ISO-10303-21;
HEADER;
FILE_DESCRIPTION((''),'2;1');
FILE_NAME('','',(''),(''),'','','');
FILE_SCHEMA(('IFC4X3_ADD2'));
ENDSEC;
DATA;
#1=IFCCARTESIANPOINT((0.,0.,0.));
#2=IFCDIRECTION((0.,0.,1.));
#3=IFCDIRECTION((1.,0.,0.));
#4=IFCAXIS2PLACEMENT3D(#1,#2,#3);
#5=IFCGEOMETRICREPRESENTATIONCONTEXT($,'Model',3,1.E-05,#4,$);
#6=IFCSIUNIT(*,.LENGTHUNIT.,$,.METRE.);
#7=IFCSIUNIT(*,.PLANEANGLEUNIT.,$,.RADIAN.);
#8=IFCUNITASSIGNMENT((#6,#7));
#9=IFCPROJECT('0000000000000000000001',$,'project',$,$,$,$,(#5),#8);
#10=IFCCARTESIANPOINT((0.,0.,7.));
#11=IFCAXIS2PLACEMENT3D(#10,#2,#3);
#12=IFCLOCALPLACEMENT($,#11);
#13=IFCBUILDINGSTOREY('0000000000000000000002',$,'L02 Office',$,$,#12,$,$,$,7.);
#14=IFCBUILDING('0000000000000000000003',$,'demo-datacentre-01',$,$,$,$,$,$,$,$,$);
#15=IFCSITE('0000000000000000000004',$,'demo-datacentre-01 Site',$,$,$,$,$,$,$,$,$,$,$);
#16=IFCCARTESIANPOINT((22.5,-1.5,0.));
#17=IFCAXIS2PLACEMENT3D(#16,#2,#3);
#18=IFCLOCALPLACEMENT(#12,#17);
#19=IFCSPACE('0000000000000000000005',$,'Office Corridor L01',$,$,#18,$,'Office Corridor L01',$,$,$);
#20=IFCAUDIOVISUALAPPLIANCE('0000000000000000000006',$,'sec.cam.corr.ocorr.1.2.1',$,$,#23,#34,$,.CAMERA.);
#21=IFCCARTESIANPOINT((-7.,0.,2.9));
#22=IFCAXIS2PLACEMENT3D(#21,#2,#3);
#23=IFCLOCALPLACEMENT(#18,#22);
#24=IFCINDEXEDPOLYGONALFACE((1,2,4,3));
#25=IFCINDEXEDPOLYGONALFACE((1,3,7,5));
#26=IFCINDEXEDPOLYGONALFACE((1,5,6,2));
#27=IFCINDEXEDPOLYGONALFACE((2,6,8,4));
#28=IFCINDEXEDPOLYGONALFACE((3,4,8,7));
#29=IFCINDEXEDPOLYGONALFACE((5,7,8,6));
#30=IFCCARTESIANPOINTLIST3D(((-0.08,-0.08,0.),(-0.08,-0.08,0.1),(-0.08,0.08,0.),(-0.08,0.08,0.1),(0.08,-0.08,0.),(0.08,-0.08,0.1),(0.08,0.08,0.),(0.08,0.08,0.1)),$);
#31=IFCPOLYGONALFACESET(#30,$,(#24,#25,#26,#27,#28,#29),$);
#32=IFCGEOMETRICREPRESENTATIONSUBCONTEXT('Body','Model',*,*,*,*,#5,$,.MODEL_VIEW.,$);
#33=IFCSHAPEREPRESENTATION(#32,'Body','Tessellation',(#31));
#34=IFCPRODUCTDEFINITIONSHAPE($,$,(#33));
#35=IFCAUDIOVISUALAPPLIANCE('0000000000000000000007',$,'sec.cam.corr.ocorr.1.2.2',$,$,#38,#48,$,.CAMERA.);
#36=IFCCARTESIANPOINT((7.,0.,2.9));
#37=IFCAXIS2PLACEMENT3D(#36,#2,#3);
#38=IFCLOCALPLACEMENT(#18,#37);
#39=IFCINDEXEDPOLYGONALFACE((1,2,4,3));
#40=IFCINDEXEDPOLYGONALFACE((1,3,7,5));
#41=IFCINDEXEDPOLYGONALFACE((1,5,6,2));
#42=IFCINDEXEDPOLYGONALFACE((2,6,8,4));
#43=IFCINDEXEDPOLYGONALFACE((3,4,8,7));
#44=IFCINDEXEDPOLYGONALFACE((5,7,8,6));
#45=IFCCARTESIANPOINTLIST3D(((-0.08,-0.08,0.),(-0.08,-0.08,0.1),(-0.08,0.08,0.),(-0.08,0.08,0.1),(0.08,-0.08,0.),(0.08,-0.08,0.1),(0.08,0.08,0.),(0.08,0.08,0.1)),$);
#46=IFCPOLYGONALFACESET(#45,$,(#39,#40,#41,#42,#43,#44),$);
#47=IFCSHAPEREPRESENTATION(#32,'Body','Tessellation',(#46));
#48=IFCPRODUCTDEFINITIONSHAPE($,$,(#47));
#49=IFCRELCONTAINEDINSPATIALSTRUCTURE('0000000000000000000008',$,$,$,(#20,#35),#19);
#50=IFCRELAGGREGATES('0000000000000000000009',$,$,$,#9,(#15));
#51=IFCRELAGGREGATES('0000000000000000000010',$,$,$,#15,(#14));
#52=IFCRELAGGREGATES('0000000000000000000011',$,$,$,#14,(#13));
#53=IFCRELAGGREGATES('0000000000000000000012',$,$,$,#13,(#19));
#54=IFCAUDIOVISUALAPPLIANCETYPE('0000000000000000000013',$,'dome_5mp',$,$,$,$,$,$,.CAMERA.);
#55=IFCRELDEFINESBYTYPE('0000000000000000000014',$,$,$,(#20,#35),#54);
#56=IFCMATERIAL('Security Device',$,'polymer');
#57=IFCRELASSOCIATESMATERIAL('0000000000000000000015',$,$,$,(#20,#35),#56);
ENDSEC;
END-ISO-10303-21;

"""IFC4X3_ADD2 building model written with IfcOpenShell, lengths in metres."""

from ifc_helpers import new_model, si_unit, frame, origin_with_axes, place, context, subcontext, project, spatial, rectangle, extrude, source, transform, mapped, material, type_object, type_shapes, element, save


model = new_model("IFC4X3_ADD2")

# Units and contexts
model_context = context("Model", 3, precision=1e-05, world=origin_with_axes())
body_context = subcontext(model_context, "Body", "Model", "MODEL_VIEW")
ifc_project = project(units=[si_unit("LENGTHUNIT", "METRE"), si_unit("PLANEANGLEUNIT", "RADIAN")], contexts=[model_context])

# Site, building, storey, space
site = spatial("IfcSite", under=ifc_project, Name="demo-datacentre-01 Site")
building = spatial("IfcBuilding", under=site, Name="demo-datacentre-01")
storey_placement = place(None, frame((0.0, 0.0, 7.0), z_axis=(0.0, 0.0, 1.0), x_axis=(1.0, 0.0, 0.0)))
storey = spatial("IfcBuildingStorey", under=building, at=storey_placement, Name="L02 Office", Elevation=7.0)
space_placement = place(storey_placement, frame((22.5, -1.5, 0.0), z_axis=(0.0, 0.0, 1.0), x_axis=(1.0, 0.0, 0.0)))
space = spatial("IfcSpace", under=storey, at=space_placement, Name="Office Corridor L01", LongName="Office Corridor L01")

# Audio visual appliances
ifc_material = material(Name="Security Device", Category="polymer")
audio_visual_appliance_type = type_object("IfcAudioVisualApplianceType", Name="dome_5mp", PredefinedType="CAMERA")
shared_shape = source(origin_with_axes(), body_context, "Body", "SweptSolid", [
    extrude(rectangle(XDim=0.16, YDim=0.16), origin_with_axes(), (0.0, 0.0, 1.0), 0.1),
])
type_shapes(audio_visual_appliance_type, [shared_shape])
for number, where, z_axis, x_axis, name in (
    (1, (-7.0, 0.0, 2.9), (0.0, 0.0, 1.0), (1.0, 0.0, 0.0), "sec.cam.corr.ocorr.1.2.1"),
    (2, (7.0, 0.0, 2.9), (0.0, 0.0, 1.0), (1.0, 0.0, 0.0), "sec.cam.corr.ocorr.1.2.2"),
):
    element("IfcAudioVisualAppliance", number, at=place(space_placement, frame(where, z_axis=z_axis, x_axis=x_axis)), inside=space, type_object=audio_visual_appliance_type, material=ifc_material, Name=name, PredefinedType="CAMERA", context=body_context, shape_type="MappedRepresentation", body=[
        mapped(shared_shape, transform((0.0, 0.0, 0.0), x_axis=(1.0, 0.0, 0.0), y_axis=(0.0, 1.0, 0.0), z_axis=(0.0, 0.0, 1.0), scale=1.0)),
    ])

save(model, "model.ifc")
